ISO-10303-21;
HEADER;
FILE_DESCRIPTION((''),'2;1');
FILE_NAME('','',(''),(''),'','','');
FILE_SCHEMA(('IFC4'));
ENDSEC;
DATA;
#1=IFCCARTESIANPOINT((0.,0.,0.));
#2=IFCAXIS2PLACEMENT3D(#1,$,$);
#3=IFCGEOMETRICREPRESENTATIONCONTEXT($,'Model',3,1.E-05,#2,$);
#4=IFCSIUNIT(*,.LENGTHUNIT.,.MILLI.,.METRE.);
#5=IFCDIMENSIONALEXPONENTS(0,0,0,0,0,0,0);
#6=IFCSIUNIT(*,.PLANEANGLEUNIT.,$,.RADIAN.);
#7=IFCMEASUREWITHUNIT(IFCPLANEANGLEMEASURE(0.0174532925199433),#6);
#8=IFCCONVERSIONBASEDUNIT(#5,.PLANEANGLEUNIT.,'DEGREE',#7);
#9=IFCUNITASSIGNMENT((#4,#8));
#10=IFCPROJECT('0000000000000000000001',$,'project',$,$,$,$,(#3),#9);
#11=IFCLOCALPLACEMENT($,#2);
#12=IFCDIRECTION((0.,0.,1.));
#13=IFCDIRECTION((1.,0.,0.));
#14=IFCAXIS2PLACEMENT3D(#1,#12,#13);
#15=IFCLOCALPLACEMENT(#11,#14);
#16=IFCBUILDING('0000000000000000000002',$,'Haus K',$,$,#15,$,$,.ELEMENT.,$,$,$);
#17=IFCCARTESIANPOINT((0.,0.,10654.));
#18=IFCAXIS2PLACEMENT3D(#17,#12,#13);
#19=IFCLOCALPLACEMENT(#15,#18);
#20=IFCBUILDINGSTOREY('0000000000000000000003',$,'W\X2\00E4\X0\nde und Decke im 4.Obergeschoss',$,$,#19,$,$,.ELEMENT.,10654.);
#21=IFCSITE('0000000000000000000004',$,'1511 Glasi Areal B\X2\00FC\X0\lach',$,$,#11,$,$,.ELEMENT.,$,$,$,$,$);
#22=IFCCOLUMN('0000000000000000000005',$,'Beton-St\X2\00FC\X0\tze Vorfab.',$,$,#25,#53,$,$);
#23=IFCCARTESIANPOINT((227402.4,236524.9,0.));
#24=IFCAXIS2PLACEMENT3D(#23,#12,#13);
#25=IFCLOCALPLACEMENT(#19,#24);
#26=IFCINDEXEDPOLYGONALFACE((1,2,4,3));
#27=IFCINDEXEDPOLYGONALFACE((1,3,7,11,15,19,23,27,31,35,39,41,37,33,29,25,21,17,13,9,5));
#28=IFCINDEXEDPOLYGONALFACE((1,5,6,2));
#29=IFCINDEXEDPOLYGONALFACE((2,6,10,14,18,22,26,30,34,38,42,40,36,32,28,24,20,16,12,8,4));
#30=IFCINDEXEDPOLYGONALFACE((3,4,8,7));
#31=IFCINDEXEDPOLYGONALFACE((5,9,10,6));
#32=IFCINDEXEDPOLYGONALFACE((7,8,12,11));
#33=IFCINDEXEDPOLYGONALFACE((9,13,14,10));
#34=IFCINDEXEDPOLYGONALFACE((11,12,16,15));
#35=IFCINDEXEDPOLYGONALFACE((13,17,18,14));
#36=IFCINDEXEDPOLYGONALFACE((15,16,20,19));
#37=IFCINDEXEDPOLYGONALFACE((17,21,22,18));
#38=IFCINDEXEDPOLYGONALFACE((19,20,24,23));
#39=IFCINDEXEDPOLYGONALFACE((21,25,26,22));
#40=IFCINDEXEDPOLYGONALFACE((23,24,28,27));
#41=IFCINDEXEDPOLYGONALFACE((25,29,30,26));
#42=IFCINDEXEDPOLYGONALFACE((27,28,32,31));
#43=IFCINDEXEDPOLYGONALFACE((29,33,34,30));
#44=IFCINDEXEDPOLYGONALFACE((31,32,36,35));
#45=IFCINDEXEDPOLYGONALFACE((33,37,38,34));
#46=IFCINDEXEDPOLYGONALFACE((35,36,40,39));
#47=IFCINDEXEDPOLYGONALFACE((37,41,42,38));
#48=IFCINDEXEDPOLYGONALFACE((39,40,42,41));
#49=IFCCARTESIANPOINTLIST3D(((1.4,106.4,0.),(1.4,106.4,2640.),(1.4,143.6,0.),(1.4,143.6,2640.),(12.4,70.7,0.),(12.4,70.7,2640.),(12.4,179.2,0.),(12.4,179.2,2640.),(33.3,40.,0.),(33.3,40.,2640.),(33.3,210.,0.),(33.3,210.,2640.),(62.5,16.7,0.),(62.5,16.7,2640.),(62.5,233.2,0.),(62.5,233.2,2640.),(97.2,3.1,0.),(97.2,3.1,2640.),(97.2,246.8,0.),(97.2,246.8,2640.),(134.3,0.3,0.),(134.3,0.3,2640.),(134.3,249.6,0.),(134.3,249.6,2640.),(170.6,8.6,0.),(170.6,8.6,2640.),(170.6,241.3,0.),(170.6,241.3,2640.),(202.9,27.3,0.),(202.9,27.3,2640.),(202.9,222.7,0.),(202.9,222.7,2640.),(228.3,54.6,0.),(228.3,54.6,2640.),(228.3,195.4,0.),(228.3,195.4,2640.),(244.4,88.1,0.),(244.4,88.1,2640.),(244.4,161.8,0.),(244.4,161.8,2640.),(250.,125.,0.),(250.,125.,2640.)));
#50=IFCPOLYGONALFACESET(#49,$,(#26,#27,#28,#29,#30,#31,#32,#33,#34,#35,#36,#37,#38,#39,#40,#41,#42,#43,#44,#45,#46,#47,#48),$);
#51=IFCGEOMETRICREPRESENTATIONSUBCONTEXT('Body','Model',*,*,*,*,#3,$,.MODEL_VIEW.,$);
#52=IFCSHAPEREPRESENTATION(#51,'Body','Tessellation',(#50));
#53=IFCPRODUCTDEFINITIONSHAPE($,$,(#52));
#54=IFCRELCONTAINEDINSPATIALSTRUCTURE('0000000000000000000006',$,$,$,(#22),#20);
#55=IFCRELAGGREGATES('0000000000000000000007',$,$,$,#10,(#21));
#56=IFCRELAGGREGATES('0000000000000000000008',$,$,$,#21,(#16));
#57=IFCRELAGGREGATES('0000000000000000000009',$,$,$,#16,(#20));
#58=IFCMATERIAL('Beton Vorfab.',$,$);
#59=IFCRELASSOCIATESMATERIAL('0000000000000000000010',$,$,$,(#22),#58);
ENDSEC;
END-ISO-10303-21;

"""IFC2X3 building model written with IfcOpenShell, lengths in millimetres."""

from ifc_helpers import new_model, entity, si_unit, converted_unit, frame, frame_2d, origin, origin_with_axes, place, context, subcontext, project, spatial, circle, extrude, material, element, save


model = new_model("IFC2X3")

# Units and contexts
model_context = context("Model", 3, precision=1e-05, world=origin())
body_context = subcontext(model_context, "Body", "Model", "MODEL_VIEW")
ifc_project = project(units=[si_unit("LENGTHUNIT", "METRE", prefix="MILLI"), converted_unit("PLANEANGLEUNIT", "DEGREE", entity("IfcPlaneAngleMeasure", 0.0174532925199433), si_unit("PLANEANGLEUNIT", "RADIAN"), dimensions=[0, 0, 0, 0, 0, 0, 0])], contexts=[model_context])

# Site, building, storey
site_placement = place(None, origin())
site = spatial("IfcSite", under=ifc_project, at=site_placement, Name="1511 Glasi Areal Bülach", CompositionType="ELEMENT")
building_placement = place(site_placement, origin_with_axes())
building = spatial("IfcBuilding", under=site, at=building_placement, Name="Haus K", CompositionType="ELEMENT")
storey_placement = place(building_placement, frame((0.0, 0.0, 10654.0), z_axis=(0.0, 0.0, 1.0), x_axis=(1.0, 0.0, 0.0)))
storey = spatial("IfcBuildingStorey", under=building, at=storey_placement, Name="Wände und Decke im 4.Obergeschoss", CompositionType="ELEMENT", Elevation=10654.0)

# Column
ifc_material_1 = material(Name="Beton Vorfab.")
column_placement = place(storey_placement, frame((227402.4, 236524.9, 0.0), z_axis=(0.0, 0.0, 1.0), x_axis=(1.0, 0.0, 0.0)))
element("IfcColumn", 1, at=column_placement, inside=storey, material=ifc_material_1, Name="Beton-Stütze Vorfab.", context=body_context, shape_type="SweptSolid", body=[
    extrude(circle(Radius=125.0, at=frame_2d((125.0, 125.0), x_axis=(1.0, 0.0))), origin_with_axes(), (0.0, 0.0, 1.0), 2640.0),
])

save(model, "model.ifc")
